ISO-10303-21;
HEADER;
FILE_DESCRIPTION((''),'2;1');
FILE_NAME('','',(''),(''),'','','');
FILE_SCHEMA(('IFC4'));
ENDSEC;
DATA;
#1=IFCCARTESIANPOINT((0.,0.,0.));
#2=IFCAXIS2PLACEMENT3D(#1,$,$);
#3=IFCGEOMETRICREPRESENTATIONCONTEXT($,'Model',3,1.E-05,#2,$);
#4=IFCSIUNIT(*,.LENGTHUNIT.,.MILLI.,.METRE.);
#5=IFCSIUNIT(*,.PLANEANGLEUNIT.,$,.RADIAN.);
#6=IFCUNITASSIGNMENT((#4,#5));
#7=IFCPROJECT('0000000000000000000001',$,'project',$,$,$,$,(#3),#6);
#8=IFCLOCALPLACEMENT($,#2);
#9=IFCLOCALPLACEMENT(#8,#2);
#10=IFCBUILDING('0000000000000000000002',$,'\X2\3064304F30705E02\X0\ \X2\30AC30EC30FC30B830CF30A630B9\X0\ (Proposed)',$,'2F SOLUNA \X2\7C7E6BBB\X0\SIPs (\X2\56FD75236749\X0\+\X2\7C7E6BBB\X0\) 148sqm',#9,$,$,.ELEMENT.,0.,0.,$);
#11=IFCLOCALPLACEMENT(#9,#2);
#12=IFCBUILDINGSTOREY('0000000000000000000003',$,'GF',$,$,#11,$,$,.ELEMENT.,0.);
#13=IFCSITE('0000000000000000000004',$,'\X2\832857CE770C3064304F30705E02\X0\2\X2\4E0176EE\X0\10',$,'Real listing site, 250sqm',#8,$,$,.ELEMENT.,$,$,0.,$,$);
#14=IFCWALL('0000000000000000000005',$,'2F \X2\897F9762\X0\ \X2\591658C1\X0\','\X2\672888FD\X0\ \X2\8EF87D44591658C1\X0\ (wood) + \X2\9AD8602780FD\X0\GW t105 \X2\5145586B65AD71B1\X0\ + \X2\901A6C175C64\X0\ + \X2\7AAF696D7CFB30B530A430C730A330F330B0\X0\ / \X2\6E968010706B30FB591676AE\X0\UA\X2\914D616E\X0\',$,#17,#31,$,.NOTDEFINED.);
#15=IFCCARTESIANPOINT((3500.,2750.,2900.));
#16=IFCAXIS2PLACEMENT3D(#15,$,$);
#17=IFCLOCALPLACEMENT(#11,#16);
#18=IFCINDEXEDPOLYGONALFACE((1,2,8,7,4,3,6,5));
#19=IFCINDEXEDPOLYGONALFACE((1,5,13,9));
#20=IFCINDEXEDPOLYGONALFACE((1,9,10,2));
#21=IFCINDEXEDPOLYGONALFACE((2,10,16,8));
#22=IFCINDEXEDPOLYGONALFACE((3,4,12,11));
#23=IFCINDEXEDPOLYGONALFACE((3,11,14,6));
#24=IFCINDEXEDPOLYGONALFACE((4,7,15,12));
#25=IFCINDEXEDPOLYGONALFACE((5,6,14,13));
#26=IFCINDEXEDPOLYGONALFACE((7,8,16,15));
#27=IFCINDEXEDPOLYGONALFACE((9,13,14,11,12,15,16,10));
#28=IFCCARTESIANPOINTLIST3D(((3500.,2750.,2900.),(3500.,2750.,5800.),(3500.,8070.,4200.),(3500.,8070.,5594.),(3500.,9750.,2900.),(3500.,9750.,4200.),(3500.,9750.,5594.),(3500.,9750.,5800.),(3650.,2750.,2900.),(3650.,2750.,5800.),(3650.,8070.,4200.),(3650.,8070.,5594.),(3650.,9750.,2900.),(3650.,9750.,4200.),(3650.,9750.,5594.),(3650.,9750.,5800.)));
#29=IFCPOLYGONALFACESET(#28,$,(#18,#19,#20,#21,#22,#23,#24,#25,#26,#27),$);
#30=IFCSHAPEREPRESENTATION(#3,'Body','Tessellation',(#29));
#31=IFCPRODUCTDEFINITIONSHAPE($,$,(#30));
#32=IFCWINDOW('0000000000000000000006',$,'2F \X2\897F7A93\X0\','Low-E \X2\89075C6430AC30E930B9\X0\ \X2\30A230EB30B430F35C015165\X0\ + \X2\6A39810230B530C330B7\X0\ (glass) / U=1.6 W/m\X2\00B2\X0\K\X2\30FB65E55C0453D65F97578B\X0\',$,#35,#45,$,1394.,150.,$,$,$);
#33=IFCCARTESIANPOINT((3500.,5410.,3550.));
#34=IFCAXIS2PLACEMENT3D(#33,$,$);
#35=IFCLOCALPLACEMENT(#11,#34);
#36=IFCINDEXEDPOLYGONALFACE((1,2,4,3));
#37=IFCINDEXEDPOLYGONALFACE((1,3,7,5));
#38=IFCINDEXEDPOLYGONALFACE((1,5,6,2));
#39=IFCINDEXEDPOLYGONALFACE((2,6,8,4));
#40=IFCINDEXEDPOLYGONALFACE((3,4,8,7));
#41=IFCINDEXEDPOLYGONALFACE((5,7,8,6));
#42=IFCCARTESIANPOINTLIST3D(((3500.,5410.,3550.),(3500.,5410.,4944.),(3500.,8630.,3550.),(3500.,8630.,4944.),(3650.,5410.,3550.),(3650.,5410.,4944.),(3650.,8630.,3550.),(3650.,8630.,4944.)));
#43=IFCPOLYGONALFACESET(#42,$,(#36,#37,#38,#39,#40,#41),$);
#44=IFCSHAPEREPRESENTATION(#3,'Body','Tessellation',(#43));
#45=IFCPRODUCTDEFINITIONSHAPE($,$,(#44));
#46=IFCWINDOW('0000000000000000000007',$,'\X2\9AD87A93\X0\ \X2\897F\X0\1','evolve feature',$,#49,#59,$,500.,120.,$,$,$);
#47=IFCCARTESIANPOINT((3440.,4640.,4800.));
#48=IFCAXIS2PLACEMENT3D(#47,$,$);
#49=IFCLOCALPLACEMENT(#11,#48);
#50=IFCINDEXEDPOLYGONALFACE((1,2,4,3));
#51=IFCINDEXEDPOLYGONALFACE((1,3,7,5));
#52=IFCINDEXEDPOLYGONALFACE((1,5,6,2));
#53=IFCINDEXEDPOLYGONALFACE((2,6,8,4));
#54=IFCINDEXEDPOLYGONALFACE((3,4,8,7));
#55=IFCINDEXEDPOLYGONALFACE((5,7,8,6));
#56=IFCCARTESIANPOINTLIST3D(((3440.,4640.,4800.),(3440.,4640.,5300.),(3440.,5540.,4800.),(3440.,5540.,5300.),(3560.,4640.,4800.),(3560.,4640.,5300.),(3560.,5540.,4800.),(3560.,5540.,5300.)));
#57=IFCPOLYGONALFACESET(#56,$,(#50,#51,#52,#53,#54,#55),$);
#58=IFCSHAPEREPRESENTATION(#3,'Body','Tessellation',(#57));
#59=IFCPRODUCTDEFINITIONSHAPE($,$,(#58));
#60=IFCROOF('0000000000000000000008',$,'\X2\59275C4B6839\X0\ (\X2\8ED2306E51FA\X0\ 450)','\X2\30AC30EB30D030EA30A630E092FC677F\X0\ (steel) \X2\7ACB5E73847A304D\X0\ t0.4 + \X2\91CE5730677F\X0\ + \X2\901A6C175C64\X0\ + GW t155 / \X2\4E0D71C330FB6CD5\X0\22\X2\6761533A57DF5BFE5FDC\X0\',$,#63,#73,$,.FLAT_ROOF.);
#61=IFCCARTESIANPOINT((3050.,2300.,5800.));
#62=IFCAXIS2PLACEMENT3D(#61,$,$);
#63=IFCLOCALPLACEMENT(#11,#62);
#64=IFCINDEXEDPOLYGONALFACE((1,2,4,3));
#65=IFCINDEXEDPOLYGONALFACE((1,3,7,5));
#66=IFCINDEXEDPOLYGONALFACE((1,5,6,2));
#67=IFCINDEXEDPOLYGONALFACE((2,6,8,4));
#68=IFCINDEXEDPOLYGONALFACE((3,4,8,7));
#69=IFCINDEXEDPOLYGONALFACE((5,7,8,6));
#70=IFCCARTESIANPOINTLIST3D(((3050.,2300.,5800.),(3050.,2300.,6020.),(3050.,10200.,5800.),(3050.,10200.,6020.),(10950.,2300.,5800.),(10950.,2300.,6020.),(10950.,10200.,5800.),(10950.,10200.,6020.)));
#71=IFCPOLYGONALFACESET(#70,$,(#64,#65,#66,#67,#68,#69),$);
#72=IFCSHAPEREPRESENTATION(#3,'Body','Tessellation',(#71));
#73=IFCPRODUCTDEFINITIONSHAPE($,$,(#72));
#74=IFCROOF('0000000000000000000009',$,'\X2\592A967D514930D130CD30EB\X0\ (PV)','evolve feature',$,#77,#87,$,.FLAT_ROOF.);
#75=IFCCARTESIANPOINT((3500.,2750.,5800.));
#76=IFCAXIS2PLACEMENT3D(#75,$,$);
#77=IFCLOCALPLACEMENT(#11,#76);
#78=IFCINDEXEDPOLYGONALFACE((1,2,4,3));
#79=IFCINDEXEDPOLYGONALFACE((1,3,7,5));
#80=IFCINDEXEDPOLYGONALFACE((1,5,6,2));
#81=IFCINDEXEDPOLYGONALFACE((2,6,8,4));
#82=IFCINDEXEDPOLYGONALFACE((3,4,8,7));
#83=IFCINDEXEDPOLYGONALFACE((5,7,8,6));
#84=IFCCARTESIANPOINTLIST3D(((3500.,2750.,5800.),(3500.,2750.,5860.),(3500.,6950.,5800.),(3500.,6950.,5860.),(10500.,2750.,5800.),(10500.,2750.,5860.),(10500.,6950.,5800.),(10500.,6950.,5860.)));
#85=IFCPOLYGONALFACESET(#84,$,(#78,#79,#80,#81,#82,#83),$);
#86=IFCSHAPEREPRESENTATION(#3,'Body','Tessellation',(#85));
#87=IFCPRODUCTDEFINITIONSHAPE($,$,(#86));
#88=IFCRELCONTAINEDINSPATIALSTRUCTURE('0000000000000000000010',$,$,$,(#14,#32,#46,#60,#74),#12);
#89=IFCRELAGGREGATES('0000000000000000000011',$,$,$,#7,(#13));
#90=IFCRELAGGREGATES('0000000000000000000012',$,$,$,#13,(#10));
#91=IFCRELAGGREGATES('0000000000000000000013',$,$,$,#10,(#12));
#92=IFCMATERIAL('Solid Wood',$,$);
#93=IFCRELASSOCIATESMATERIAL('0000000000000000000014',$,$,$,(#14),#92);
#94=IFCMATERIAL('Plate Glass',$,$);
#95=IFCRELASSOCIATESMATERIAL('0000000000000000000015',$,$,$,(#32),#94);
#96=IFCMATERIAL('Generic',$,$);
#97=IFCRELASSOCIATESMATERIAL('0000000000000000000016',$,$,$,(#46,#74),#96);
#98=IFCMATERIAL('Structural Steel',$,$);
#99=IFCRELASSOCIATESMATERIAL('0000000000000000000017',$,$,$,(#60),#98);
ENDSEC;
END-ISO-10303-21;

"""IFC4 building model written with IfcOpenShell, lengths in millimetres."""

from ifc_helpers import new_model, si_unit, frame, frame_2d, origin, place, context, project, spatial, rectangle, extrude, material, element, fill, save


model = new_model("IFC4")

# Units and contexts
model_context = context("Model", 3, precision=1e-05, world=origin())
ifc_project = project(units=[si_unit("LENGTHUNIT", "METRE", prefix="MILLI"), si_unit("PLANEANGLEUNIT", "RADIAN")], contexts=[model_context])

# Site, building, storey
site_placement = place(None, origin())
site = spatial("IfcSite", under=ifc_project, at=site_placement, Name="茨城県つくば市2丁目10", ObjectType="Real listing site, 250sqm", CompositionType="ELEMENT", RefElevation=0.0)
building_placement = place(site_placement, origin())
building = spatial("IfcBuilding", under=site, at=building_placement, Name="つくば市 ガレージハウス (Proposed)", ObjectType="2F SOLUNA 籾殻SIPs (国産杉+籾殻) 148sqm", CompositionType="ELEMENT", ElevationOfRefHeight=0.0, ElevationOfTerrain=0.0)
storey_placement = place(building_placement, origin())
storey = spatial("IfcBuildingStorey", under=building, at=storey_placement, Name="GF", CompositionType="ELEMENT", Elevation=0.0)

# Shared definitions
ifc_material_1 = material(Name="Solid Wood")
ifc_material_2 = material(Name="Generic")

# Shared definitions
ifc_material_3 = material(Name="Plate Glass")

# Wall, openings, windows
wall_1_placement = place(storey_placement, frame((3500.0, 2750.0, 2900.0)))
wall_1 = element("IfcWall", 1, at=wall_1_placement, inside=storey, material=ifc_material_1, Name="2F 西面 外壁", Description="木製 軸組外壁 (wood) + 高性能GW t105 充填断熱 + 通気層 + 窯業系サイディング / 準耐火・外皮UA配慮", PredefinedType="NOTDEFINED", context=model_context, shape_type="SweptSolid", body=[
    extrude(rectangle(XDim=150.0, YDim=7000.0, at=frame_2d((75.0, 3500.0))), frame((3500.0, 2750.0, 2900.0)), (0.0, 0.0, 1.0), 2900.0),
])
opening_1_placement = place(storey_placement, frame((3500.0, 5410.0, 3550.0)))
opening_1 = element("IfcOpeningElement", 2, at=opening_1_placement, cuts=wall_1, PredefinedType="NOTDEFINED", context=model_context, shape_type="SweptSolid", body=[
    extrude(rectangle(XDim=150.0, YDim=3220.0, at=frame_2d((75.0, 1610.0))), frame((3500.0, 5410.0, 3550.0)), (0.0, 0.0, 1.0), 1394.0),
])
opening_2_placement = place(storey_placement, frame((3440.0, 4640.0, 4800.0)))
opening_2 = element("IfcOpeningElement", 3, at=opening_2_placement, cuts=wall_1, PredefinedType="NOTDEFINED", context=model_context, shape_type="SweptSolid", body=[
    extrude(rectangle(XDim=120.0, YDim=900.0, at=frame_2d((60.0, 450.0))), frame((3440.0, 4640.0, 4800.0)), (0.0, 0.0, 1.0), 500.0),
])
window_1_placement = place(storey_placement, frame((3500.0, 5410.0, 3550.0)))
window_1 = element("IfcWindow", 4, at=window_1_placement, inside=storey, material=ifc_material_3, Name="2F 西窓", Description="Low-E 複層ガラス アルゴン封入 + 樹脂サッシ (glass) / U=1.6 W/m²K・日射取得型", OverallHeight=1394.0, OverallWidth=150.0, context=model_context, shape_type="SweptSolid", body=[
    extrude(rectangle(XDim=150.0, YDim=3220.0, at=frame_2d((75.0, 1610.0))), frame((3500.0, 5410.0, 3550.0)), (0.0, 0.0, 1.0), 1394.0),
])
fill(opening_1, window_1)
window_2_placement = place(storey_placement, frame((3440.0, 4640.0, 4800.0)))
window_2 = element("IfcWindow", 5, at=window_2_placement, inside=storey, material=ifc_material_2, Name="高窓 西1", Description="evolve feature", OverallHeight=500.0, OverallWidth=120.0, context=model_context, shape_type="SweptSolid", body=[
    extrude(rectangle(XDim=120.0, YDim=900.0, at=frame_2d((60.0, 450.0))), frame((3440.0, 4640.0, 4800.0)), (0.0, 0.0, 1.0), 500.0),
])
fill(opening_2, window_2)

# Roofs
ifc_material_4 = material(Name="Structural Steel")
roof_1_placement = place(storey_placement, frame((3050.0, 2300.0, 5800.0)))
element("IfcRoof", 6, at=roof_1_placement, inside=storey, material=ifc_material_4, Name="大屋根 (軒の出 450)", Description="ガルバリウム鋼板 (steel) 立平葺き t0.4 + 野地板 + 通気層 + GW t155 / 不燃・法22条区域対応", PredefinedType="FLAT_ROOF", context=model_context, shape_type="SweptSolid", body=[
    extrude(rectangle(XDim=7900.0, YDim=7900.0, at=frame_2d((3950.0, 3950.0))), frame((3050.0, 2300.0, 5800.0)), (0.0, 0.0, 1.0), 220.0),
])
roof_2_placement = place(storey_placement, frame((3500.0, 2750.0, 5800.0)))
element("IfcRoof", 7, at=roof_2_placement, inside=storey, material=ifc_material_2, Name="太陽光パネル (PV)", Description="evolve feature", PredefinedType="FLAT_ROOF", context=model_context, shape_type="SweptSolid", body=[
    extrude(rectangle(XDim=7000.0, YDim=4200.0, at=frame_2d((3500.0, 2100.0))), frame((3500.0, 2750.0, 5800.0)), (0.0, 0.0, 1.0), 60.0),
])

save(model, "model.ifc")
